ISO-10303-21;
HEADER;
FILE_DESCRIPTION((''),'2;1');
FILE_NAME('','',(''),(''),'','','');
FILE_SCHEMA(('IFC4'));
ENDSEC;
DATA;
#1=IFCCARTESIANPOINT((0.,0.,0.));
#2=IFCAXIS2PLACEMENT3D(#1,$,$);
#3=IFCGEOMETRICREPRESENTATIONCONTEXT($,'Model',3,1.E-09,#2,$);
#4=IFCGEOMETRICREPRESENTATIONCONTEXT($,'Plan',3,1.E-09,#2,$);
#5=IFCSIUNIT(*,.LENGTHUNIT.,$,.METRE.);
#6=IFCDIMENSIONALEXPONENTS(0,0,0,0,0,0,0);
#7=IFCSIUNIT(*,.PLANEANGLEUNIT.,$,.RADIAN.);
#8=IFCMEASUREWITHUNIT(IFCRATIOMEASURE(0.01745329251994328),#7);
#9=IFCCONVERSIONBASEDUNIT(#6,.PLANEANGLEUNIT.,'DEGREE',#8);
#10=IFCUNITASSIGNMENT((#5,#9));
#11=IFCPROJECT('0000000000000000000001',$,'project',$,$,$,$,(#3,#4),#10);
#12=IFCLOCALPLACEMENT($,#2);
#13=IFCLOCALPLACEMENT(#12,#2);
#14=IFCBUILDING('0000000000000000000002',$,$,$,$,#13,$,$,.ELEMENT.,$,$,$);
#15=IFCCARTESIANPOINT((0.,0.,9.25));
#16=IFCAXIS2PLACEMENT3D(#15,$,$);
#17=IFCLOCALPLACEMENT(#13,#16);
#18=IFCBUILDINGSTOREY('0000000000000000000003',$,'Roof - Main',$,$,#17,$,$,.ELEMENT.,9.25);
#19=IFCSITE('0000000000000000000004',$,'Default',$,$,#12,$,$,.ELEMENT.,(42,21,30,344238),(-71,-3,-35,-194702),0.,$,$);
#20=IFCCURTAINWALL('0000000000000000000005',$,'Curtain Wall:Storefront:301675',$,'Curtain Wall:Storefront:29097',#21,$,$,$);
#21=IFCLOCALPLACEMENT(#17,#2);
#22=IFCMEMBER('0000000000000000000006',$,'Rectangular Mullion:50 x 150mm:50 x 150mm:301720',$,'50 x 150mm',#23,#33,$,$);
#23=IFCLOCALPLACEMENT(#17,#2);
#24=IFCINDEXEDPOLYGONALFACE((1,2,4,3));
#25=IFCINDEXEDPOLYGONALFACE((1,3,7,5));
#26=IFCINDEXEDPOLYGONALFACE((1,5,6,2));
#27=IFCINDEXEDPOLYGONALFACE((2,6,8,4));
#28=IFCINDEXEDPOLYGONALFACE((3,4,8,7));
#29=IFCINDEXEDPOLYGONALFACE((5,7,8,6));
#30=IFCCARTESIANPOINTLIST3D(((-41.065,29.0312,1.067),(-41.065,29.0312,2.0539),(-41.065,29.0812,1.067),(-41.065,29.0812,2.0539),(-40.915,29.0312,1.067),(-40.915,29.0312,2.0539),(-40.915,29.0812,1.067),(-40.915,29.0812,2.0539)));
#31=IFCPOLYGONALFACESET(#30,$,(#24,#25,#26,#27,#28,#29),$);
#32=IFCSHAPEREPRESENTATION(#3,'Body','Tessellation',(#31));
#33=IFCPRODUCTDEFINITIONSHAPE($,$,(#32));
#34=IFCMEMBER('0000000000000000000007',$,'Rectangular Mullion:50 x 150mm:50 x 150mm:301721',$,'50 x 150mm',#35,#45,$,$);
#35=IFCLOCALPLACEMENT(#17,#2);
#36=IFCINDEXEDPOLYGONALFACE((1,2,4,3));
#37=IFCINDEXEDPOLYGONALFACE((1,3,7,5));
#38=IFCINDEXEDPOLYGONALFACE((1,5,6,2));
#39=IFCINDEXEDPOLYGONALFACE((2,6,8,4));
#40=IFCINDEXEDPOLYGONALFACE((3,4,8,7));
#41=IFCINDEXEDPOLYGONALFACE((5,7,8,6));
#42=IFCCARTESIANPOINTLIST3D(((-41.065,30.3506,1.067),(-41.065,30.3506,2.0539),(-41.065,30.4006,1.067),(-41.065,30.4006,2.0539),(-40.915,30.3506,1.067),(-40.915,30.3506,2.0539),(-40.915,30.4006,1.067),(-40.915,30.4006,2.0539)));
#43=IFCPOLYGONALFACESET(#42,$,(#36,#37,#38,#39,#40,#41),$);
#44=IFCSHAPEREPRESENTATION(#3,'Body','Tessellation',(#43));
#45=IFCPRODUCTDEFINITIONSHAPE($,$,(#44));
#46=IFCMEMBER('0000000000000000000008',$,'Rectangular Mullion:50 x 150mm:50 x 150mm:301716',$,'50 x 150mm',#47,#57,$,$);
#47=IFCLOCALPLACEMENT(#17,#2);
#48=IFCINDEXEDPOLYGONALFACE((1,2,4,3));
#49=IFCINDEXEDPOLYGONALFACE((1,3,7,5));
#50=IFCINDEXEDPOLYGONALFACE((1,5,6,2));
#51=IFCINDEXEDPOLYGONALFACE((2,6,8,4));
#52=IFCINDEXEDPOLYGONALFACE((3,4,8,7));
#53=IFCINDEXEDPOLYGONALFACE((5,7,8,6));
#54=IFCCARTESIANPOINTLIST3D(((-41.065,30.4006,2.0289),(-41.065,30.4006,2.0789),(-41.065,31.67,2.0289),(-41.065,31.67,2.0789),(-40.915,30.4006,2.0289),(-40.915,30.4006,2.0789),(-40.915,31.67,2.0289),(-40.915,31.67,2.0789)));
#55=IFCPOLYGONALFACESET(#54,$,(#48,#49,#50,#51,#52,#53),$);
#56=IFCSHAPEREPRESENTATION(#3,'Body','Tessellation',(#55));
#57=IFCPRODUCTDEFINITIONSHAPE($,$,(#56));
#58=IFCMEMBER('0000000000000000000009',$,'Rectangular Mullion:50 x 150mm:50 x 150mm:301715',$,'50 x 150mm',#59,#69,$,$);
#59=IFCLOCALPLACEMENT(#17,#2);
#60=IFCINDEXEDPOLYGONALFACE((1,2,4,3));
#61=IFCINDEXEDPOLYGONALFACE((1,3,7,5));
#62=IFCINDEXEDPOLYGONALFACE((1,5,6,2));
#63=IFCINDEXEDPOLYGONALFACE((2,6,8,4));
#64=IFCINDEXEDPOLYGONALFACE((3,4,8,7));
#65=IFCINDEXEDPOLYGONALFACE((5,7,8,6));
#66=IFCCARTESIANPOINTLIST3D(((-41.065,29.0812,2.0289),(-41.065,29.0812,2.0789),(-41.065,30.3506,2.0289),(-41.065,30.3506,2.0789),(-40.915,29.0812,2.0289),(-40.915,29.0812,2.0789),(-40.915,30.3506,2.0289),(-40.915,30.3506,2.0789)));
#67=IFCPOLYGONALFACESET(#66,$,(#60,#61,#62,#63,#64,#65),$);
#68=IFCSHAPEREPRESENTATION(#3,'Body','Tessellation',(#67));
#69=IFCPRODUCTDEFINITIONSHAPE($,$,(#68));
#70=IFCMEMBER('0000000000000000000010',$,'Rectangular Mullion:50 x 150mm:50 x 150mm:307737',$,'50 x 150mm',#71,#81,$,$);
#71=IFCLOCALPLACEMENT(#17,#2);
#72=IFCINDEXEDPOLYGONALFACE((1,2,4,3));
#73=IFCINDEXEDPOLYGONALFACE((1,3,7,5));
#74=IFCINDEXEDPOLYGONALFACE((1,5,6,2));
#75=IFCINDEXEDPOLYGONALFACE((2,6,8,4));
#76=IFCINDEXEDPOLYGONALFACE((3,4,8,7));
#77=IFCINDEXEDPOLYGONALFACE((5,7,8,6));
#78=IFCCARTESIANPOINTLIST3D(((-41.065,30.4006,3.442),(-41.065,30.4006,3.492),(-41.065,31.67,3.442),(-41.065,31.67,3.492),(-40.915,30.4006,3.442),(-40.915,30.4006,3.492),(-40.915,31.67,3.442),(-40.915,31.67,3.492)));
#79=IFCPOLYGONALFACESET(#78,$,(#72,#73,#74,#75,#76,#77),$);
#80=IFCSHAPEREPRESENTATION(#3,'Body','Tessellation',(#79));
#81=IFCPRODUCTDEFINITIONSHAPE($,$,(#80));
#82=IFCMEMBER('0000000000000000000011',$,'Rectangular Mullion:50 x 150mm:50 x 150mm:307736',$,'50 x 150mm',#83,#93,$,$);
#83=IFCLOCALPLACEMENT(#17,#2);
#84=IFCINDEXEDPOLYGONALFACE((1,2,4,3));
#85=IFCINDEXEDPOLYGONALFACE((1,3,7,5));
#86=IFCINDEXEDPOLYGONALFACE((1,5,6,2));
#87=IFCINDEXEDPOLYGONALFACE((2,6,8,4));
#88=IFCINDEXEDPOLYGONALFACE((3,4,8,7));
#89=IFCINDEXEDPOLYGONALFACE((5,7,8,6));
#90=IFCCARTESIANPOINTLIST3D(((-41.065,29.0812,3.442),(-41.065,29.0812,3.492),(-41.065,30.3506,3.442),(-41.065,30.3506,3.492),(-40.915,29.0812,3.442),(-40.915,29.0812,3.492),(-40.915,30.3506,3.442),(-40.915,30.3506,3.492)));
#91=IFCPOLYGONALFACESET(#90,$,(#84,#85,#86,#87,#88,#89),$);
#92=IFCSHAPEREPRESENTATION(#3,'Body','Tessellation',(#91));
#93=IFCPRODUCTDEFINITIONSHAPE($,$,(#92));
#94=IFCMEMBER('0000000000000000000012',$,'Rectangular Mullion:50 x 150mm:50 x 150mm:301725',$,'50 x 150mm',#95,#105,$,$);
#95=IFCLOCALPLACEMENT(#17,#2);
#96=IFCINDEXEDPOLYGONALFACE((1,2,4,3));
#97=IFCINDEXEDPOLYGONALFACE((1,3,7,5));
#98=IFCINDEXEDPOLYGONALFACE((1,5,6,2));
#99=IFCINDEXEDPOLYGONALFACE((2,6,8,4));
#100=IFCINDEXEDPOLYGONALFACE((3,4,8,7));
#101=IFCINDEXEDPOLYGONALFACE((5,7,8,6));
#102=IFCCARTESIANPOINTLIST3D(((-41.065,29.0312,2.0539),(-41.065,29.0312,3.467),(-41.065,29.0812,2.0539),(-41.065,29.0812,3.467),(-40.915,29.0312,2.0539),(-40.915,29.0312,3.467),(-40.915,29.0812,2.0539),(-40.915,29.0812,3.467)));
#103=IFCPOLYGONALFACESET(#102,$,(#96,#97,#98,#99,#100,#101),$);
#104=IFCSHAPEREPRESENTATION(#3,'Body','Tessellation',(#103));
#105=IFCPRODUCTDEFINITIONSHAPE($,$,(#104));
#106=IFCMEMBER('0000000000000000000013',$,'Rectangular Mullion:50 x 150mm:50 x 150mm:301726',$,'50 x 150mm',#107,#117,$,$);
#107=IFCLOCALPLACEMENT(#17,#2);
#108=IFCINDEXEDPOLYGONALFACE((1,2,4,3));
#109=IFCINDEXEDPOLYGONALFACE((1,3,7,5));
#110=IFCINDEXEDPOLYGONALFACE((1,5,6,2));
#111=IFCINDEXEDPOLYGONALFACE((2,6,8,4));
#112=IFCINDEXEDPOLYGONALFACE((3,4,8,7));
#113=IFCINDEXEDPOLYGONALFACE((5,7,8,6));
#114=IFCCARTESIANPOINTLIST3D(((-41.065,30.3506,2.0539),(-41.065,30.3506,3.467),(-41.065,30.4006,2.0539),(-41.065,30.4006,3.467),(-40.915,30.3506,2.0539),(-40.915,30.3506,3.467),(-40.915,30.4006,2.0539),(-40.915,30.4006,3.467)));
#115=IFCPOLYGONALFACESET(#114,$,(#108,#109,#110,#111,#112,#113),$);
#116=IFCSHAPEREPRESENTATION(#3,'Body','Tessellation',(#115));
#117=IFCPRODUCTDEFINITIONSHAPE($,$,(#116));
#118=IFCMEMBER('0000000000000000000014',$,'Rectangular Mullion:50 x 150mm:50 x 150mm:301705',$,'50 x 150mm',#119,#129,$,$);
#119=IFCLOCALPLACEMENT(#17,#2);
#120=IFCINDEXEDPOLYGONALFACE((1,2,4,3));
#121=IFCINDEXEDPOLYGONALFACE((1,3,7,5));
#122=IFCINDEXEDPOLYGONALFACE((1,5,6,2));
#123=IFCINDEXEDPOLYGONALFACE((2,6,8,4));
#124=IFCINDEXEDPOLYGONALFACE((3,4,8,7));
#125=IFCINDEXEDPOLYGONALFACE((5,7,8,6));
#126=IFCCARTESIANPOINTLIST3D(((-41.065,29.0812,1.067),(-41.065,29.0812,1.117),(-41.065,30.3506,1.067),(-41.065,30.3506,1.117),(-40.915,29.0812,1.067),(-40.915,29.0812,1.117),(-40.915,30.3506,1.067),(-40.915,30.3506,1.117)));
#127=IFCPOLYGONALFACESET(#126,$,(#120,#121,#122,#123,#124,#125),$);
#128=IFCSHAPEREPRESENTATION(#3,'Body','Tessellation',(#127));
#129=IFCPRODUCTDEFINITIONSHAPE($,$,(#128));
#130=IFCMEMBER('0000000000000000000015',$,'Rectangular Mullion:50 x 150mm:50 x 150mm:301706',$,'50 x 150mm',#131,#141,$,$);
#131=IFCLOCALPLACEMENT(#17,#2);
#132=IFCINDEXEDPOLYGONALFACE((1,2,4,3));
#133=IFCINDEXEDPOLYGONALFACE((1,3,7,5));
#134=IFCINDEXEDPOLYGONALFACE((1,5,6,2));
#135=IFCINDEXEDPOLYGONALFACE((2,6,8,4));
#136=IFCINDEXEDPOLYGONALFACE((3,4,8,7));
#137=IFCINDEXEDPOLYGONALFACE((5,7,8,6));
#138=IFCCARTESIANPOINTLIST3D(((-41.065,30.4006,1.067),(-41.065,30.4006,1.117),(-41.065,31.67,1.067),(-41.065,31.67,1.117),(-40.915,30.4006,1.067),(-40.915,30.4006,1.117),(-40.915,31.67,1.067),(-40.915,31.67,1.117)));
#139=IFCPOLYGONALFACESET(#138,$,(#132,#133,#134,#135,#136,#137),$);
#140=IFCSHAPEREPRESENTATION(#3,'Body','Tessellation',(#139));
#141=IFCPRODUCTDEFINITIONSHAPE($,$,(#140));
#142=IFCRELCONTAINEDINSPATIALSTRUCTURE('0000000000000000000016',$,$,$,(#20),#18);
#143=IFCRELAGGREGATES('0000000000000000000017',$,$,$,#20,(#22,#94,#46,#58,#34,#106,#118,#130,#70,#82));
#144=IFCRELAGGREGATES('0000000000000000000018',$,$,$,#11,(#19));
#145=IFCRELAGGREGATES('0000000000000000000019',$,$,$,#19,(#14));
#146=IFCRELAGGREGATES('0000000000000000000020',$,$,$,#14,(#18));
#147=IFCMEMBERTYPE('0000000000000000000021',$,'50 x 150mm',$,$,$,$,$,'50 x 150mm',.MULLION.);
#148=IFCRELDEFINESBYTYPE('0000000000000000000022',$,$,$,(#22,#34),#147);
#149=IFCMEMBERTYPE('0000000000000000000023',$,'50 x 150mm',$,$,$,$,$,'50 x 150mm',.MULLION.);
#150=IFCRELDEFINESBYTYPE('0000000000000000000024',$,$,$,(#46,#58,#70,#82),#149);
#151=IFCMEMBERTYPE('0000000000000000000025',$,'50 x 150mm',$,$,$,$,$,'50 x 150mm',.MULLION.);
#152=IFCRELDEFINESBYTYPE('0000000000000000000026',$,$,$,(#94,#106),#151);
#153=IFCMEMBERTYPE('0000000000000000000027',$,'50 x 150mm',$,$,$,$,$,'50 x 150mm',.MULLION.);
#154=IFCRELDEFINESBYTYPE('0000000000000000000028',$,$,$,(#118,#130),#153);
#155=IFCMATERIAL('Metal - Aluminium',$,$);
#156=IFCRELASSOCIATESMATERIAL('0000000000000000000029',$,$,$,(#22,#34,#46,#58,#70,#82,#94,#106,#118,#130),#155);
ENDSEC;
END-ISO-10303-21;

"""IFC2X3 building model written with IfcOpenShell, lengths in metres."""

from ifc_helpers import new_model, entity, si_unit, converted_unit, frame, origin, origin_2d_with_axis, place, context, project, spatial, rectangle, extrude, source, transform, mapped, material, type_object, type_shapes, element, aggregate, save


model = new_model("IFC2X3")

# Units and contexts
model_context = context("Model", 3, precision=1e-09, world=origin())
plan_context = context("Plan", 3, precision=1e-09, world=origin())
ifc_project = project(units=[si_unit("LENGTHUNIT", "METRE"), converted_unit("PLANEANGLEUNIT", "DEGREE", entity("IfcRatioMeasure", 0.01745329251994328), si_unit("PLANEANGLEUNIT", "RADIAN"), dimensions=[0, 0, 0, 0, 0, 0, 0])], contexts=[model_context, plan_context])

# Site, building, storey
site_placement = place(None, origin())
site = spatial("IfcSite", under=ifc_project, at=site_placement, Name="Default", CompositionType="ELEMENT", RefLatitude=(42, 21, 30, 344238), RefLongitude=(-71, -3, -35, -194702), RefElevation=0.0)
building_placement = place(site_placement, origin())
building = spatial("IfcBuilding", under=site, at=building_placement, CompositionType="ELEMENT")
storey_placement = place(building_placement, frame((0.0, 0.0, 9.25)))
storey = spatial("IfcBuildingStorey", under=building, at=storey_placement, Name="Roof - Main", CompositionType="ELEMENT", Elevation=9.25)

# Curtain wall, members
curtain_wall_placement = place(storey_placement, origin())
curtain_wall = element("IfcCurtainWall", 1, at=curtain_wall_placement, inside=storey, Name="Curtain Wall:Storefront:301675", ObjectType="Curtain Wall:Storefront:29097")
ifc_material_1 = material(Name="Metal - Aluminium")
member_type_1 = type_object("IfcMemberType", Name="50 x 150mm", ElementType="50 x 150mm", PredefinedType="MULLION")
shared_shape_1 = source(origin(), model_context, "Body", "SweptSolid", [
    extrude(rectangle(XDim=0.05, YDim=0.15, at=origin_2d_with_axis()), frame((0.0, 0.0, -0.9869), z_axis=(0.0, 0.0, 1.0), x_axis=(-1.0, 0.0, 0.0)), (0.0, 0.0, 1.0), 0.9869),
])
type_shapes(member_type_1, [shared_shape_1])
member_1_placement = place(storey_placement, frame((-40.99, 29.0562, 1.067), z_axis=(0.0, 0.0, -1.0), x_axis=(0.0, 1.0, 0.0)))
member_1 = element("IfcMember", 2, at=member_1_placement, type_object=member_type_1, material=ifc_material_1, Name="Rectangular Mullion:50 x 150mm:50 x 150mm:301720", ObjectType="50 x 150mm", context=model_context, shape_type="MappedRepresentation", body=[
    mapped(shared_shape_1, transform((0.0, 0.0, 0.0), scale=1.0)),
])
member_2_placement = place(storey_placement, frame((-40.99, 30.3756, 1.067), z_axis=(0.0, 0.0, -1.0), x_axis=(0.0, 1.0, 0.0)))
member_2 = element("IfcMember", 3, at=member_2_placement, type_object=member_type_1, material=ifc_material_1, Name="Rectangular Mullion:50 x 150mm:50 x 150mm:301721", ObjectType="50 x 150mm", context=model_context, shape_type="MappedRepresentation", body=[
    mapped(shared_shape_1, transform((0.0, 0.0, 0.0), scale=1.0)),
])
member_type_2 = type_object("IfcMemberType", Name="50 x 150mm", ElementType="50 x 150mm", PredefinedType="MULLION")
shared_shape_2 = source(origin(), model_context, "Body", "SweptSolid", [
    extrude(rectangle(XDim=0.05, YDim=0.15, at=origin_2d_with_axis()), frame((0.0, 0.0, -1.2694), z_axis=(0.0, 0.0, 1.0), x_axis=(-1.0, 0.0, 0.0)), (0.0, 0.0, 1.0), 1.2694),
])
type_shapes(member_type_2, [shared_shape_2])
member_3_placement = place(storey_placement, frame((-40.99, 31.67, 2.0539), z_axis=(0.0, 1.0, 0.0), x_axis=(0.0, 0.0, 1.0)))
member_3 = element("IfcMember", 4, at=member_3_placement, type_object=member_type_2, material=ifc_material_1, Name="Rectangular Mullion:50 x 150mm:50 x 150mm:301716", ObjectType="50 x 150mm", context=model_context, shape_type="MappedRepresentation", body=[
    mapped(shared_shape_2, transform((0.0, 0.0, 0.0), scale=1.0)),
])
member_4_placement = place(storey_placement, frame((-40.99, 30.3506, 2.0539), z_axis=(0.0, 1.0, 0.0), x_axis=(0.0, 0.0, 1.0)))
member_4 = element("IfcMember", 5, at=member_4_placement, type_object=member_type_2, material=ifc_material_1, Name="Rectangular Mullion:50 x 150mm:50 x 150mm:301715", ObjectType="50 x 150mm", context=model_context, shape_type="MappedRepresentation", body=[
    mapped(shared_shape_2, transform((0.0, 0.0, 0.0), scale=1.0)),
])
member_5_placement = place(storey_placement, frame((-40.99, 31.67, 3.467), z_axis=(0.0, 1.0, 0.0), x_axis=(0.0, 0.0, 1.0)))
member_5 = element("IfcMember", 6, at=member_5_placement, type_object=member_type_2, material=ifc_material_1, Name="Rectangular Mullion:50 x 150mm:50 x 150mm:307737", ObjectType="50 x 150mm", context=model_context, shape_type="MappedRepresentation", body=[
    mapped(shared_shape_2, transform((0.0, 0.0, 0.0), scale=1.0)),
])
member_6_placement = place(storey_placement, frame((-40.99, 30.3506, 3.467), z_axis=(0.0, 1.0, 0.0), x_axis=(0.0, 0.0, 1.0)))
member_6 = element("IfcMember", 7, at=member_6_placement, type_object=member_type_2, material=ifc_material_1, Name="Rectangular Mullion:50 x 150mm:50 x 150mm:307736", ObjectType="50 x 150mm", context=model_context, shape_type="MappedRepresentation", body=[
    mapped(shared_shape_2, transform((0.0, 0.0, 0.0), scale=1.0)),
])
member_type_3 = type_object("IfcMemberType", Name="50 x 150mm", ElementType="50 x 150mm", PredefinedType="MULLION")
shared_shape_3 = source(origin(), model_context, "Body", "SweptSolid", [
    extrude(rectangle(XDim=0.05, YDim=0.15, at=origin_2d_with_axis()), frame((0.0, 0.0, -1.4131), z_axis=(0.0, 0.0, 1.0), x_axis=(-1.0, 0.0, 0.0)), (0.0, 0.0, 1.0), 1.4131),
])
type_shapes(member_type_3, [shared_shape_3])
member_7_placement = place(storey_placement, frame((-40.99, 29.0562, 2.0539), z_axis=(0.0, 0.0, -1.0), x_axis=(0.0, 1.0, 0.0)))
member_7 = element("IfcMember", 8, at=member_7_placement, type_object=member_type_3, material=ifc_material_1, Name="Rectangular Mullion:50 x 150mm:50 x 150mm:301725", ObjectType="50 x 150mm", context=model_context, shape_type="MappedRepresentation", body=[
    mapped(shared_shape_3, transform((0.0, 0.0, 0.0), scale=1.0)),
])
member_8_placement = place(storey_placement, frame((-40.99, 30.3756, 2.0539), z_axis=(0.0, 0.0, -1.0), x_axis=(0.0, 1.0, 0.0)))
member_8 = element("IfcMember", 9, at=member_8_placement, type_object=member_type_3, material=ifc_material_1, Name="Rectangular Mullion:50 x 150mm:50 x 150mm:301726", ObjectType="50 x 150mm", context=model_context, shape_type="MappedRepresentation", body=[
    mapped(shared_shape_3, transform((0.0, 0.0, 0.0), scale=1.0)),
])
member_type_4 = type_object("IfcMemberType", Name="50 x 150mm", ElementType="50 x 150mm", PredefinedType="MULLION")
shared_shape_4 = source(origin(), model_context, "Body", "SweptSolid", [
    extrude(rectangle(XDim=0.05, YDim=0.15, at=origin_2d_with_axis()), frame((-0.025, 0.0, -1.2694), z_axis=(0.0, 0.0, 1.0), x_axis=(-1.0, 0.0, 0.0)), (0.0, 0.0, 1.0), 1.2694),
])
type_shapes(member_type_4, [shared_shape_4])
member_9_placement = place(storey_placement, frame((-40.99, 29.0812, 1.067), z_axis=(0.0, -1.0, 0.0), x_axis=(0.0, 0.0, -1.0)))
member_9 = element("IfcMember", 10, at=member_9_placement, type_object=member_type_4, material=ifc_material_1, Name="Rectangular Mullion:50 x 150mm:50 x 150mm:301705", ObjectType="50 x 150mm", context=model_context, shape_type="MappedRepresentation", body=[
    mapped(shared_shape_4, transform((0.0, 0.0, 0.0), scale=1.0)),
])
member_10_placement = place(storey_placement, frame((-40.99, 30.4006, 1.067), z_axis=(0.0, -1.0, 0.0), x_axis=(0.0, 0.0, -1.0)))
member_10 = element("IfcMember", 11, at=member_10_placement, type_object=member_type_4, material=ifc_material_1, Name="Rectangular Mullion:50 x 150mm:50 x 150mm:301706", ObjectType="50 x 150mm", context=model_context, shape_type="MappedRepresentation", body=[
    mapped(shared_shape_4, transform((0.0, 0.0, 0.0), scale=1.0)),
])
aggregate(curtain_wall, [member_1, member_7, member_3, member_4, member_2, member_8, member_9, member_10, member_5, member_6])

save(model, "model.ifc")
